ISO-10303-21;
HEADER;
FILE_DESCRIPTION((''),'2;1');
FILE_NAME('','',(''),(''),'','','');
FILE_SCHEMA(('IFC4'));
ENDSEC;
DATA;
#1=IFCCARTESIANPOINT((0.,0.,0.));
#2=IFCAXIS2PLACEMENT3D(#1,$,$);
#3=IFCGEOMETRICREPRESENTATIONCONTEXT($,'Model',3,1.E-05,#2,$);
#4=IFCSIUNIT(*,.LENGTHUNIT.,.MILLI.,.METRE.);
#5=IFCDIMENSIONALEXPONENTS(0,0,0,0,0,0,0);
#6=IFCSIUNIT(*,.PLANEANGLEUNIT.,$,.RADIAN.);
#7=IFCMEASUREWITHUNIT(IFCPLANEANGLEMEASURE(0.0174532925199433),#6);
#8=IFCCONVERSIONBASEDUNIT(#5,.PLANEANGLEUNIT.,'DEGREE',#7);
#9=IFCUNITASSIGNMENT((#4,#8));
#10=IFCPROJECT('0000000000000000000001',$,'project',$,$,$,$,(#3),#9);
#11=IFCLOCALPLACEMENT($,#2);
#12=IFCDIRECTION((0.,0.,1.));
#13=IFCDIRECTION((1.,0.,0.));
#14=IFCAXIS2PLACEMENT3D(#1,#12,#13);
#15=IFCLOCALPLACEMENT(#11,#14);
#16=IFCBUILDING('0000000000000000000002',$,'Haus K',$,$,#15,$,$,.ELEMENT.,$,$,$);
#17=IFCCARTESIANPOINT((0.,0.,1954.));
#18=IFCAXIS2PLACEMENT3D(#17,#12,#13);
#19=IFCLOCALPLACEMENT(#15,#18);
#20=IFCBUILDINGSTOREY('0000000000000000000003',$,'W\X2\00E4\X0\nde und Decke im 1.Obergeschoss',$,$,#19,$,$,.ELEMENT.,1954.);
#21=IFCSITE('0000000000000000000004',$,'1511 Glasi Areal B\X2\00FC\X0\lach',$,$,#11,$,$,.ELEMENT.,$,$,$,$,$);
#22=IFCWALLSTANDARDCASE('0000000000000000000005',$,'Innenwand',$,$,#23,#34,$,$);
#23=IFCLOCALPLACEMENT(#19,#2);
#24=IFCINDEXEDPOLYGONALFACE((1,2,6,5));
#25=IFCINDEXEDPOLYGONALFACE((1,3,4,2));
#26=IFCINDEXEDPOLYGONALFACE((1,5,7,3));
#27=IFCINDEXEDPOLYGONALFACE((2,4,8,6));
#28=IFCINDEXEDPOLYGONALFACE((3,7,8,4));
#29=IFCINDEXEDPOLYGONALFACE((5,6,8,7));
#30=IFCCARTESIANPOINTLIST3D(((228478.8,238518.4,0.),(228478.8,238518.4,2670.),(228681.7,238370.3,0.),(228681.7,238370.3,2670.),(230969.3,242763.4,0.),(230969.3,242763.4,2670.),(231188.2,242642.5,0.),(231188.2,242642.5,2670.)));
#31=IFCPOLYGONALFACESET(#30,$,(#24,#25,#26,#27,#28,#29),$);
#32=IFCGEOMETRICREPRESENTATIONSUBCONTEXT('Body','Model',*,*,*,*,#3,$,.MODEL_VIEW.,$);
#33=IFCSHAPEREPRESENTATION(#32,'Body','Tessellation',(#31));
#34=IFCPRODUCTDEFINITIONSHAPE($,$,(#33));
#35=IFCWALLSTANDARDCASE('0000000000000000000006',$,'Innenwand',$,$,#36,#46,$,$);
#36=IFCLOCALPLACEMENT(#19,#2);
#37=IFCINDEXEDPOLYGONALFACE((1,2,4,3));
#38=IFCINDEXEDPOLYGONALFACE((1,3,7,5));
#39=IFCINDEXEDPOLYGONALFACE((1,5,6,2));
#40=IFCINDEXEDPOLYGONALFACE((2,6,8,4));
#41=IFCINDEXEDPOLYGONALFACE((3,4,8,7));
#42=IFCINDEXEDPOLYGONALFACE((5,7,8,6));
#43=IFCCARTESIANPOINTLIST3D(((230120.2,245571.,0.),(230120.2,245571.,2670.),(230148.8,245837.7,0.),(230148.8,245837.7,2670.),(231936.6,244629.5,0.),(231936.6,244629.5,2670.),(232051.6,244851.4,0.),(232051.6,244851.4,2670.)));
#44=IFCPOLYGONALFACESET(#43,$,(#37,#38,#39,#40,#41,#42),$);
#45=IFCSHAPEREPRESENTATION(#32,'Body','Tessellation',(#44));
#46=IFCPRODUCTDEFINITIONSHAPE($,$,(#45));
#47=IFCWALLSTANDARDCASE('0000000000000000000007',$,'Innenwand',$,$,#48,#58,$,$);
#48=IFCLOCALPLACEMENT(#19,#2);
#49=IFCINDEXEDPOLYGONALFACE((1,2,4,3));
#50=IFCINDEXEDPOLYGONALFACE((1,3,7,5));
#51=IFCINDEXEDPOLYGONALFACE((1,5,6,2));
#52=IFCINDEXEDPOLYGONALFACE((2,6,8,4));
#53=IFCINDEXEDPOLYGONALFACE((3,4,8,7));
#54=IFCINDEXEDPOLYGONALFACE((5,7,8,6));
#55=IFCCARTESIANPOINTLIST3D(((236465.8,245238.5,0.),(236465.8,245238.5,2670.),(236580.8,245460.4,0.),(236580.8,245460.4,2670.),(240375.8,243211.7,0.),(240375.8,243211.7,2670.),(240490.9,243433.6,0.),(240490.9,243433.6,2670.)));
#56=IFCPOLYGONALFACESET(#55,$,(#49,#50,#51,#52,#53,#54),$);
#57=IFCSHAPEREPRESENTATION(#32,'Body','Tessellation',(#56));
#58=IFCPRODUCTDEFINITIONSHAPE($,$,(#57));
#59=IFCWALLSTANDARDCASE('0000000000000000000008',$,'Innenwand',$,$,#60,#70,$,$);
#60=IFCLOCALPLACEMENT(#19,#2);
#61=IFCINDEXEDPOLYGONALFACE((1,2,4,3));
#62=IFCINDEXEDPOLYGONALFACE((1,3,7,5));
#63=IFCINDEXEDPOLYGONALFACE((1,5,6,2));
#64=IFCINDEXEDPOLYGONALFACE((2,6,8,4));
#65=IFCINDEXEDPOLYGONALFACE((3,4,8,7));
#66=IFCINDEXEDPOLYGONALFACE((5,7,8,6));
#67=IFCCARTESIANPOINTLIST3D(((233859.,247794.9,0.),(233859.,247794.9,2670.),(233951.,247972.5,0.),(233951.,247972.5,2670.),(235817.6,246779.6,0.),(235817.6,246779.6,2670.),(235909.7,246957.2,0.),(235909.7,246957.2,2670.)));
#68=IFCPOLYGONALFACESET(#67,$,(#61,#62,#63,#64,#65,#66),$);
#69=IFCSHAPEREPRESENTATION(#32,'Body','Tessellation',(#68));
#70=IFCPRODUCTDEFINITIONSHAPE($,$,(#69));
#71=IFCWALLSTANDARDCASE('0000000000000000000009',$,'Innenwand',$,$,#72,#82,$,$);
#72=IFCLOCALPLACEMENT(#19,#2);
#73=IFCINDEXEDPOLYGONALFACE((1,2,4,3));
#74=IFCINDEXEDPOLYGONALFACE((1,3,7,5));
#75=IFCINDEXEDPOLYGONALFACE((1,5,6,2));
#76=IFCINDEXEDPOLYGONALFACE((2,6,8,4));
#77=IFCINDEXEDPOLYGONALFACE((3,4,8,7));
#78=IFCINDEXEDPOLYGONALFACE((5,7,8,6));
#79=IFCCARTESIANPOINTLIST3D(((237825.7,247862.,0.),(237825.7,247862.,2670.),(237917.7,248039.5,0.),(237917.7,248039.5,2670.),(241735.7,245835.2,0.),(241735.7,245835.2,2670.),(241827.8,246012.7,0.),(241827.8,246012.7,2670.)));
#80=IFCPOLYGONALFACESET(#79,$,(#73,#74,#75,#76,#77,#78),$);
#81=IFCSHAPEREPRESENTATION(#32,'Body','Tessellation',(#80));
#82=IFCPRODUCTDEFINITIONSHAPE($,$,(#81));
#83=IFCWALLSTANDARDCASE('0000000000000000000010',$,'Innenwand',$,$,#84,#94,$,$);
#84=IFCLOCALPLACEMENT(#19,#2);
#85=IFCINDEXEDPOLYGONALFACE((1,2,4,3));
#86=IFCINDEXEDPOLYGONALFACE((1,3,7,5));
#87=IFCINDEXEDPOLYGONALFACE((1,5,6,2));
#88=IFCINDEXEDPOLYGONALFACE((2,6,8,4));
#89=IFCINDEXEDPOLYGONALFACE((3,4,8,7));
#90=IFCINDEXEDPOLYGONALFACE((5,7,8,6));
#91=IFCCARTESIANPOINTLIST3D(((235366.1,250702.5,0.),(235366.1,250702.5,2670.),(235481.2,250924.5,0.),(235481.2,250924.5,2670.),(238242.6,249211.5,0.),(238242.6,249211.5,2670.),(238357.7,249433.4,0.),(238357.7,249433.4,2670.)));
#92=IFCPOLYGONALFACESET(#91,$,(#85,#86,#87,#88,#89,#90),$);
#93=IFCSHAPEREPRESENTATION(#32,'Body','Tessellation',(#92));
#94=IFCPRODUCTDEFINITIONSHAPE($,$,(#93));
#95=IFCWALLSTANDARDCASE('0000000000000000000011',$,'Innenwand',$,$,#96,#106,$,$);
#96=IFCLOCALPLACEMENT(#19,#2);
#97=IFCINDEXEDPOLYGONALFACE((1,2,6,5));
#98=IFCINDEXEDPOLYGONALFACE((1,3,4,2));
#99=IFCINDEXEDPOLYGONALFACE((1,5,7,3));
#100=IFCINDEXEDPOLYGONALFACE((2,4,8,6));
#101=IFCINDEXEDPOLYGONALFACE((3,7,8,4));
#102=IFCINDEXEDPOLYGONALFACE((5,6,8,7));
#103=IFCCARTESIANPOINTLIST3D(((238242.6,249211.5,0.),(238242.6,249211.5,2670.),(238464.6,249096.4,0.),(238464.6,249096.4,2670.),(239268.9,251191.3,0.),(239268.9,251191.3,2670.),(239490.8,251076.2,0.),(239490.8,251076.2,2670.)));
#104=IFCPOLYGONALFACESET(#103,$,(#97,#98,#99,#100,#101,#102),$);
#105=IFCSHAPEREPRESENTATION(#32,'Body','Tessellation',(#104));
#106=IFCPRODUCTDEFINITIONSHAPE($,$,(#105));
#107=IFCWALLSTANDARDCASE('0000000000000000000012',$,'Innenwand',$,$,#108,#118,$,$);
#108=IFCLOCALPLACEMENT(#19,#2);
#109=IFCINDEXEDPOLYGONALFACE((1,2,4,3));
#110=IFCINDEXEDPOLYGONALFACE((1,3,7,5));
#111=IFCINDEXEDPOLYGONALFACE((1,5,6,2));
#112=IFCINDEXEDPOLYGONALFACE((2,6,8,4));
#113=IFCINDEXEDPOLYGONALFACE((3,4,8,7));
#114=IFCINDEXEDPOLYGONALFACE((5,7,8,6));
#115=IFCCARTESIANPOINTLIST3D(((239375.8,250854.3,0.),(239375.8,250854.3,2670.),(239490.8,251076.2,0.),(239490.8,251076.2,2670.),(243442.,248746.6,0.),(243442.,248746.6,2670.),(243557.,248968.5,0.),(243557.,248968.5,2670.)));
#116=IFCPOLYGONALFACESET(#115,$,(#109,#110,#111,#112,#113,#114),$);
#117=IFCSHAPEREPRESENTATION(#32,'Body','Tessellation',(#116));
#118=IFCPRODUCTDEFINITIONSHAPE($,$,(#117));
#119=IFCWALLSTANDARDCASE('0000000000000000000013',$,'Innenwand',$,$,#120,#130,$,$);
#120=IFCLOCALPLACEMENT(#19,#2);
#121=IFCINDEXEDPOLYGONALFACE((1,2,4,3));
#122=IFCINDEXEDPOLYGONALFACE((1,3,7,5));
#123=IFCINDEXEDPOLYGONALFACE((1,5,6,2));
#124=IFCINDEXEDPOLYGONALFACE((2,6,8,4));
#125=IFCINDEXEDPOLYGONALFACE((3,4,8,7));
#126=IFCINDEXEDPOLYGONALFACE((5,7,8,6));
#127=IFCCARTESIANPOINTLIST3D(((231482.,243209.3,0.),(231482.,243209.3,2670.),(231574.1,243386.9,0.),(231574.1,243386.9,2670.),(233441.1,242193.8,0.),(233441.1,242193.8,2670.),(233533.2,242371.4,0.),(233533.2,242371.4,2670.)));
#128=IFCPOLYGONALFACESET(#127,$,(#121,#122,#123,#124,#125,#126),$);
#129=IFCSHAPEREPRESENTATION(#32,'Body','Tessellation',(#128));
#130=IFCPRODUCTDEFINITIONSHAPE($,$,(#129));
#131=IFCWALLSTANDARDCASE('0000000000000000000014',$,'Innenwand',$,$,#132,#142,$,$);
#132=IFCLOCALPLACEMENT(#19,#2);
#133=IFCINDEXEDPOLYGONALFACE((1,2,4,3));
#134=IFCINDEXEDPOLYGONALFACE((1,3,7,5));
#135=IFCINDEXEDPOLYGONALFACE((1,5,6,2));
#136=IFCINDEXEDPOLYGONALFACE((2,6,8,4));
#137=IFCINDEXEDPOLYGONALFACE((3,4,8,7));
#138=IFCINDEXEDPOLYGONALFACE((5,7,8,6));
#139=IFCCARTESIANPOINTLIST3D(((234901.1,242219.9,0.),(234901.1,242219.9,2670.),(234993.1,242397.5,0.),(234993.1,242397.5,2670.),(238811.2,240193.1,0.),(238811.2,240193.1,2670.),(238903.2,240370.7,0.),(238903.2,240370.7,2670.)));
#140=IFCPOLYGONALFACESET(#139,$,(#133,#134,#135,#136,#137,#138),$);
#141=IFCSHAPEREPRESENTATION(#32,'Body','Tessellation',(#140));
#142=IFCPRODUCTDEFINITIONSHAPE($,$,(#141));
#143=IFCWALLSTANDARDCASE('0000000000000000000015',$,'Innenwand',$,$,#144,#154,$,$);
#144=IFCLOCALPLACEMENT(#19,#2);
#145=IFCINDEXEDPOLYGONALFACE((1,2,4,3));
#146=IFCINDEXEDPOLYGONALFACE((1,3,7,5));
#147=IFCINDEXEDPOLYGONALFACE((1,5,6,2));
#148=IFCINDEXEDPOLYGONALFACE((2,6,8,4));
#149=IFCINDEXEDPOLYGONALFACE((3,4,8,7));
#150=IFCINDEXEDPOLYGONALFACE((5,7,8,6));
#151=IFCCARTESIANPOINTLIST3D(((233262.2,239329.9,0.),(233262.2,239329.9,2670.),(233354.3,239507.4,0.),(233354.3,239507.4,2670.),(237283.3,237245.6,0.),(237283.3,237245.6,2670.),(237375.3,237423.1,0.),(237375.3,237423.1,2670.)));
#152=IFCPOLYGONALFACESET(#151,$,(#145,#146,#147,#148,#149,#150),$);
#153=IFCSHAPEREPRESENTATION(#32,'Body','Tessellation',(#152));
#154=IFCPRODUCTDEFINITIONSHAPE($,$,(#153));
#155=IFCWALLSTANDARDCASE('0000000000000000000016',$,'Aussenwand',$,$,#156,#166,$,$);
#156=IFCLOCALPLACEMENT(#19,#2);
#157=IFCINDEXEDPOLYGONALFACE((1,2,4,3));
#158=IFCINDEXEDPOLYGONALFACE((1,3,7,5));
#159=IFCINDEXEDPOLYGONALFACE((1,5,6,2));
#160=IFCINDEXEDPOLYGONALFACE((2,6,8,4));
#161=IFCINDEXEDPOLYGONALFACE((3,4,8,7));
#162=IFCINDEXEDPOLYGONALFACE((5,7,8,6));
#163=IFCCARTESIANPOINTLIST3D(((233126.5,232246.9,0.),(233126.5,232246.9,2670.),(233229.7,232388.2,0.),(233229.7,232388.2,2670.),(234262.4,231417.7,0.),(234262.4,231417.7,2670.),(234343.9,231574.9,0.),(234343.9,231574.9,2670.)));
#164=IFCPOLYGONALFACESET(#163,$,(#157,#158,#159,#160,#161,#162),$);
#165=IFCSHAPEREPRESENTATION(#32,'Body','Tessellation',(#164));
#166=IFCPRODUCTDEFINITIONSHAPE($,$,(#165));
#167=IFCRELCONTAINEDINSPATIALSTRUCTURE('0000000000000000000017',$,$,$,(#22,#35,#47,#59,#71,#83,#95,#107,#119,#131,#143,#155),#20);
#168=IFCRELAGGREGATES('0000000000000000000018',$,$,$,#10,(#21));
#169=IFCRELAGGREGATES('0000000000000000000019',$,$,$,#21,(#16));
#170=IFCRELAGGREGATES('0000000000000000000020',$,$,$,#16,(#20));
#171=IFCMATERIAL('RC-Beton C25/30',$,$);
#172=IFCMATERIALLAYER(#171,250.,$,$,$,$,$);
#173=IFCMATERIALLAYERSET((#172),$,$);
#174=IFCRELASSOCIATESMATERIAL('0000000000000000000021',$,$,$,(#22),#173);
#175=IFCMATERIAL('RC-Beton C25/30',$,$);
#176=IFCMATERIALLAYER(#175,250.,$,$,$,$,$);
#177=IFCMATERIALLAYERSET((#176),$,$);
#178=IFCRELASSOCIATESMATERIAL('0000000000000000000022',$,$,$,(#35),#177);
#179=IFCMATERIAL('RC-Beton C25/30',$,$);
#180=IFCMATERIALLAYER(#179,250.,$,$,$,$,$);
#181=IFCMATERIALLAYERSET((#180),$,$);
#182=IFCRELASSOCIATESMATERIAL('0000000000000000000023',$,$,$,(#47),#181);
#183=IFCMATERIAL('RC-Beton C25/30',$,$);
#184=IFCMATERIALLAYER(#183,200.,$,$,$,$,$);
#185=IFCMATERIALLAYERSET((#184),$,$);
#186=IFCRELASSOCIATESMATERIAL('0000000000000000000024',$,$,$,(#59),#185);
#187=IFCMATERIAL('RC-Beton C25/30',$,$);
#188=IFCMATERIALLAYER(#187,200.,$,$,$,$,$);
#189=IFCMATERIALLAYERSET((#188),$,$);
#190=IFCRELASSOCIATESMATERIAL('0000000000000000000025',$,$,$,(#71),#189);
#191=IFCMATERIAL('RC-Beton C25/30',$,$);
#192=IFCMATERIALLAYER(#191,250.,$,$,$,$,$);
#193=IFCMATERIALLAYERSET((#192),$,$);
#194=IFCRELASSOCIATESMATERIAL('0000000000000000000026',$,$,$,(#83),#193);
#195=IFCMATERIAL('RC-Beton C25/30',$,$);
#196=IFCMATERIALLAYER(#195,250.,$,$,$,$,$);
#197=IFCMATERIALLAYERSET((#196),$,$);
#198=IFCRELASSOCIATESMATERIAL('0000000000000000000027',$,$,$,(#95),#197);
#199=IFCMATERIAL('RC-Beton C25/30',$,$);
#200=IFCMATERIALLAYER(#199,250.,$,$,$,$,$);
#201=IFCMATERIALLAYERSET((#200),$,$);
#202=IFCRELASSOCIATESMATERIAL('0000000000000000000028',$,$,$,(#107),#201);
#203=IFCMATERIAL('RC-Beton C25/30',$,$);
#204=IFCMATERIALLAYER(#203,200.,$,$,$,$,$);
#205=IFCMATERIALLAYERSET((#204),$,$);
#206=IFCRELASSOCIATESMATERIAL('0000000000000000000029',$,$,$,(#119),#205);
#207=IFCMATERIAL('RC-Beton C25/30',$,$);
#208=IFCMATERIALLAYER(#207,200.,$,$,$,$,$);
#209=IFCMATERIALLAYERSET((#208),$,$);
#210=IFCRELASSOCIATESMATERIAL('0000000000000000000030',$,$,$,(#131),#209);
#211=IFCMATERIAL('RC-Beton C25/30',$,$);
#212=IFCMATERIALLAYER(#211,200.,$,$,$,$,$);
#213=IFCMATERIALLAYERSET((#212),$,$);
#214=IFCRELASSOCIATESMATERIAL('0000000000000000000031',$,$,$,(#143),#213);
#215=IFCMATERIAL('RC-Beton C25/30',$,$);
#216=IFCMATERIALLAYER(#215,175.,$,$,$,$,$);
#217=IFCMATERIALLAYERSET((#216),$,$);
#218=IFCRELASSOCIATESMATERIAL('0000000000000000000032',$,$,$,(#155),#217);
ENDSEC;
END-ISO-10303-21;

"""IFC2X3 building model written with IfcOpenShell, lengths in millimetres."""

from ifc_helpers import new_model, entity, si_unit, converted_unit, frame, frame_2d, origin, origin_with_axes, place, context, subcontext, project, spatial, polyline, rectangle, outline, extrude, material, layer, layer_set, layer_usage, element, save


model = new_model("IFC2X3")

# Units and contexts
model_context = context("Model", 3, precision=1e-05, world=origin())
body_context = subcontext(model_context, "Body", "Model", "MODEL_VIEW")
ifc_project = project(units=[si_unit("LENGTHUNIT", "METRE", prefix="MILLI"), converted_unit("PLANEANGLEUNIT", "DEGREE", entity("IfcPlaneAngleMeasure", 0.0174532925199433), si_unit("PLANEANGLEUNIT", "RADIAN"), dimensions=[0, 0, 0, 0, 0, 0, 0])], contexts=[model_context])

# Site, building, storey
site_placement = place(None, origin())
site = spatial("IfcSite", under=ifc_project, at=site_placement, Name="1511 Glasi Areal Bülach", CompositionType="ELEMENT")
building_placement = place(site_placement, origin_with_axes())
building = spatial("IfcBuilding", under=site, at=building_placement, Name="Haus K", CompositionType="ELEMENT")
storey_placement = place(building_placement, frame((0.0, 0.0, 1954.0), z_axis=(0.0, 0.0, 1.0), x_axis=(1.0, 0.0, 0.0)))
storey = spatial("IfcBuildingStorey", under=building, at=storey_placement, Name="Wände und Decke im 1.Obergeschoss", CompositionType="ELEMENT", Elevation=1954.0)

# Walls
ifc_material_1 = material(Name="RC-Beton C25/30")
ifc_layer_1 = layer(ifc_material_1, 250.0)
ifc_layer_set_1 = layer_set([ifc_layer_1])
ifc_layer_usage_1 = layer_usage(ifc_layer_set_1, "AXIS2", "POSITIVE", 0.0)
wall_1_placement = place(storey_placement, frame((230969.3, 242763.4, 0.0), z_axis=(0.0, 0.0, 1.0), x_axis=(-0.506034, -0.862514, 0.0)))
element("IfcWallStandardCase", 1, at=wall_1_placement, inside=storey, material=ifc_layer_usage_1, Name="Innenwand", context=body_context, shape_type="SweptSolid", body=[
    extrude(outline(polyline([(0.0, 0.0), (4921.6, 0.0), (4946.7, 250.0), (-6.5, 250.0), (0.0, 0.0)])), origin_with_axes(), (0.0, 0.0, 1.0), 2670.0),
])
ifc_material_2 = material(Name="RC-Beton C25/30")
ifc_layer_2 = layer(ifc_material_2, 250.0)
ifc_layer_set_2 = layer_set([ifc_layer_2])
ifc_layer_usage_2 = layer_usage(ifc_layer_set_2, "AXIS2", "POSITIVE", 0.0)
wall_2_placement = place(storey_placement, frame((232051.6, 244851.4, 0.0), z_axis=(0.0, 0.0, 1.0), x_axis=(-0.887815, 0.4602, 0.0)))
element("IfcWallStandardCase", 2, at=wall_2_placement, inside=storey, material=ifc_layer_usage_2, Name="Innenwand", context=body_context, shape_type="SweptSolid", body=[
    extrude(outline(polyline([(0.0, 0.0), (2143.2, 0.0), (2045.9, 250.0), (0.0, 250.0), (0.0, 0.0)])), origin_with_axes(), (0.0, 0.0, 1.0), 2670.0),
])
ifc_material_3 = material(Name="RC-Beton C25/30")
ifc_layer_3 = layer(ifc_material_3, 250.0)
ifc_layer_set_3 = layer_set([ifc_layer_3])
ifc_layer_usage_3 = layer_usage(ifc_layer_set_3, "AXIS2", "POSITIVE", 0.0)
wall_3_placement = place(storey_placement, frame((240490.9, 243433.6, 0.0), z_axis=(0.0, 0.0, 1.0), x_axis=(-0.887815, 0.4602, 0.0)))
element("IfcWallStandardCase", 3, at=wall_3_placement, inside=storey, material=ifc_layer_usage_3, Name="Innenwand", context=body_context, shape_type="SweptSolid", body=[
    extrude(rectangle(XDim=4404.2, YDim=250.0, at=frame_2d((2202.1, 125.0), x_axis=(1.0, 0.0))), origin_with_axes(), (0.0, 0.0, 1.0), 2670.0),
])
ifc_material_4 = material(Name="RC-Beton C25/30")
ifc_layer_4 = layer(ifc_material_4, 200.0)
ifc_layer_set_4 = layer_set([ifc_layer_4])
ifc_layer_usage_4 = layer_usage(ifc_layer_set_4, "AXIS2", "POSITIVE", 0.0)
wall_4_placement = place(storey_placement, frame((235909.7, 246957.2, 0.0), z_axis=(0.0, 0.0, 1.0), x_axis=(-0.887815, 0.4602, 0.0)))
element("IfcWallStandardCase", 4, at=wall_4_placement, inside=storey, material=ifc_layer_usage_4, Name="Innenwand", context=body_context, shape_type="SweptSolid", body=[
    extrude(rectangle(XDim=2206.2, YDim=200.0, at=frame_2d((1103.1, 100.0), x_axis=(1.0, 0.0))), origin_with_axes(), (0.0, 0.0, 1.0), 2670.0),
])
ifc_material_5 = material(Name="RC-Beton C25/30")
ifc_layer_5 = layer(ifc_material_5, 200.0)
ifc_layer_set_5 = layer_set([ifc_layer_5])
ifc_layer_usage_5 = layer_usage(ifc_layer_set_5, "AXIS2", "POSITIVE", 0.0)
wall_5_placement = place(storey_placement, frame((241827.8, 246012.7, 0.0), z_axis=(0.0, 0.0, 1.0), x_axis=(-0.887815, 0.4602, 0.0)))
element("IfcWallStandardCase", 5, at=wall_5_placement, inside=storey, material=ifc_layer_usage_5, Name="Innenwand", context=body_context, shape_type="SweptSolid", body=[
    extrude(rectangle(XDim=4404.2, YDim=200.0, at=frame_2d((2202.1, 100.0), x_axis=(1.0, 0.0))), origin_with_axes(), (0.0, 0.0, 1.0), 2670.0),
])
ifc_material_6 = material(Name="RC-Beton C25/30")
ifc_layer_6 = layer(ifc_material_6, 250.0)
ifc_layer_set_6 = layer_set([ifc_layer_6])
ifc_layer_usage_6 = layer_usage(ifc_layer_set_6, "AXIS2", "POSITIVE", 0.0)
wall_6_placement = place(storey_placement, frame((238357.7, 249433.4, 0.0), z_axis=(0.0, 0.0, 1.0), x_axis=(-0.887815, 0.4602, 0.0)))
element("IfcWallStandardCase", 6, at=wall_6_placement, inside=storey, material=ifc_layer_usage_6, Name="Innenwand", context=body_context, shape_type="SweptSolid", body=[
    extrude(rectangle(XDim=3240.0, YDim=250.0, at=frame_2d((1620.0, 125.0), x_axis=(1.0, 0.0))), origin_with_axes(), (0.0, 0.0, 1.0), 2670.0),
])
ifc_material_7 = material(Name="RC-Beton C25/30")
ifc_layer_7 = layer(ifc_material_7, 250.0)
ifc_layer_set_7 = layer_set([ifc_layer_7])
ifc_layer_usage_7 = layer_usage(ifc_layer_set_7, "AXIS2", "POSITIVE", 0.0)
wall_7_placement = place(storey_placement, frame((238464.6, 249096.4, 0.0), z_axis=(0.0, 0.0, 1.0), x_axis=(0.4602, 0.887815, 0.0)))
element("IfcWallStandardCase", 7, at=wall_7_placement, inside=storey, material=ifc_layer_usage_7, Name="Innenwand", context=body_context, shape_type="SweptSolid", body=[
    extrude(rectangle(XDim=2230.0, YDim=250.0, at=frame_2d((1115.0, 125.0), x_axis=(1.0, 0.0))), origin_with_axes(), (0.0, 0.0, 1.0), 2670.0),
])
ifc_material_8 = material(Name="RC-Beton C25/30")
ifc_layer_8 = layer(ifc_material_8, 250.0)
ifc_layer_set_8 = layer_set([ifc_layer_8])
ifc_layer_usage_8 = layer_usage(ifc_layer_set_8, "AXIS2", "POSITIVE", 0.0)
wall_8_placement = place(storey_placement, frame((239375.8, 250854.3, 0.0), z_axis=(0.0, 0.0, 1.0), x_axis=(0.887815, -0.4602, 0.0)))
element("IfcWallStandardCase", 8, at=wall_8_placement, inside=storey, material=ifc_layer_usage_8, Name="Innenwand", context=body_context, shape_type="SweptSolid", body=[
    extrude(rectangle(XDim=4580.0, YDim=250.0, at=frame_2d((2290.0, 125.0), x_axis=(1.0, 0.0))), origin_with_axes(), (0.0, 0.0, 1.0), 2670.0),
])
ifc_material_9 = material(Name="RC-Beton C25/30")
ifc_layer_9 = layer(ifc_material_9, 200.0)
ifc_layer_set_9 = layer_set([ifc_layer_9])
ifc_layer_usage_9 = layer_usage(ifc_layer_set_9, "AXIS2", "POSITIVE", 0.0)
wall_9_placement = place(storey_placement, frame((233533.2, 242371.4, 0.0), z_axis=(0.0, 0.0, 1.0), x_axis=(-0.887815, 0.4602, 0.0)))
element("IfcWallStandardCase", 9, at=wall_9_placement, inside=storey, material=ifc_layer_usage_9, Name="Innenwand", context=body_context, shape_type="SweptSolid", body=[
    extrude(rectangle(XDim=2206.6, YDim=200.0, at=frame_2d((1103.3, 100.0), x_axis=(1.0, 0.0))), origin_with_axes(), (0.0, 0.0, 1.0), 2670.0),
])
ifc_material_10 = material(Name="RC-Beton C25/30")
ifc_layer_10 = layer(ifc_material_10, 200.0)
ifc_layer_set_10 = layer_set([ifc_layer_10])
ifc_layer_usage_10 = layer_usage(ifc_layer_set_10, "AXIS2", "POSITIVE", 0.0)
wall_10_placement = place(storey_placement, frame((238903.2, 240370.7, 0.0), z_axis=(0.0, 0.0, 1.0), x_axis=(-0.887815, 0.4602, 0.0)))
element("IfcWallStandardCase", 10, at=wall_10_placement, inside=storey, material=ifc_layer_usage_10, Name="Innenwand", context=body_context, shape_type="SweptSolid", body=[
    extrude(rectangle(XDim=4404.2, YDim=200.0, at=frame_2d((2202.1, 100.0), x_axis=(1.0, 0.0))), origin_with_axes(), (0.0, 0.0, 1.0), 2670.0),
])
ifc_material_11 = material(Name="RC-Beton C25/30")
ifc_layer_11 = layer(ifc_material_11, 200.0)
ifc_layer_set_11 = layer_set([ifc_layer_11])
ifc_layer_usage_11 = layer_usage(ifc_layer_set_11, "AXIS2", "POSITIVE", 0.0)
wall_11_placement = place(storey_placement, frame((233262.2, 239329.9, 0.0), z_axis=(0.0, 0.0, 1.0), x_axis=(0.887815, -0.4602, 0.0)))
element("IfcWallStandardCase", 11, at=wall_11_placement, inside=storey, material=ifc_layer_usage_11, Name="Innenwand", context=body_context, shape_type="SweptSolid", body=[
    extrude(rectangle(XDim=4529.2, YDim=200.0, at=frame_2d((2264.6, 100.0), x_axis=(1.0, 0.0))), origin_with_axes(), (0.0, 0.0, 1.0), 2670.0),
])
ifc_material_12 = material(Name="RC-Beton C25/30")
ifc_layer_12 = layer(ifc_material_12, 175.0)
ifc_layer_set_12 = layer_set([ifc_layer_12])
ifc_layer_usage_12 = layer_usage(ifc_layer_set_12, "AXIS2", "POSITIVE", 0.0)
wall_12_placement = place(storey_placement, frame((233126.5, 232246.9, 0.0), z_axis=(0.0, 0.0, 1.0), x_axis=(0.807681, -0.589619, 0.0)))
element("IfcWallStandardCase", 12, at=wall_12_placement, inside=storey, material=ifc_layer_usage_12, Name="Aussenwand", context=body_context, shape_type="SweptSolid", body=[
    extrude(outline(polyline([(0.0, 0.0), (1406.3, 0.0), (1379.5, 175.0), (0.0, 175.0), (0.0, 0.0)])), origin_with_axes(), (0.0, 0.0, 1.0), 2670.0),
])

save(model, "model.ifc")
